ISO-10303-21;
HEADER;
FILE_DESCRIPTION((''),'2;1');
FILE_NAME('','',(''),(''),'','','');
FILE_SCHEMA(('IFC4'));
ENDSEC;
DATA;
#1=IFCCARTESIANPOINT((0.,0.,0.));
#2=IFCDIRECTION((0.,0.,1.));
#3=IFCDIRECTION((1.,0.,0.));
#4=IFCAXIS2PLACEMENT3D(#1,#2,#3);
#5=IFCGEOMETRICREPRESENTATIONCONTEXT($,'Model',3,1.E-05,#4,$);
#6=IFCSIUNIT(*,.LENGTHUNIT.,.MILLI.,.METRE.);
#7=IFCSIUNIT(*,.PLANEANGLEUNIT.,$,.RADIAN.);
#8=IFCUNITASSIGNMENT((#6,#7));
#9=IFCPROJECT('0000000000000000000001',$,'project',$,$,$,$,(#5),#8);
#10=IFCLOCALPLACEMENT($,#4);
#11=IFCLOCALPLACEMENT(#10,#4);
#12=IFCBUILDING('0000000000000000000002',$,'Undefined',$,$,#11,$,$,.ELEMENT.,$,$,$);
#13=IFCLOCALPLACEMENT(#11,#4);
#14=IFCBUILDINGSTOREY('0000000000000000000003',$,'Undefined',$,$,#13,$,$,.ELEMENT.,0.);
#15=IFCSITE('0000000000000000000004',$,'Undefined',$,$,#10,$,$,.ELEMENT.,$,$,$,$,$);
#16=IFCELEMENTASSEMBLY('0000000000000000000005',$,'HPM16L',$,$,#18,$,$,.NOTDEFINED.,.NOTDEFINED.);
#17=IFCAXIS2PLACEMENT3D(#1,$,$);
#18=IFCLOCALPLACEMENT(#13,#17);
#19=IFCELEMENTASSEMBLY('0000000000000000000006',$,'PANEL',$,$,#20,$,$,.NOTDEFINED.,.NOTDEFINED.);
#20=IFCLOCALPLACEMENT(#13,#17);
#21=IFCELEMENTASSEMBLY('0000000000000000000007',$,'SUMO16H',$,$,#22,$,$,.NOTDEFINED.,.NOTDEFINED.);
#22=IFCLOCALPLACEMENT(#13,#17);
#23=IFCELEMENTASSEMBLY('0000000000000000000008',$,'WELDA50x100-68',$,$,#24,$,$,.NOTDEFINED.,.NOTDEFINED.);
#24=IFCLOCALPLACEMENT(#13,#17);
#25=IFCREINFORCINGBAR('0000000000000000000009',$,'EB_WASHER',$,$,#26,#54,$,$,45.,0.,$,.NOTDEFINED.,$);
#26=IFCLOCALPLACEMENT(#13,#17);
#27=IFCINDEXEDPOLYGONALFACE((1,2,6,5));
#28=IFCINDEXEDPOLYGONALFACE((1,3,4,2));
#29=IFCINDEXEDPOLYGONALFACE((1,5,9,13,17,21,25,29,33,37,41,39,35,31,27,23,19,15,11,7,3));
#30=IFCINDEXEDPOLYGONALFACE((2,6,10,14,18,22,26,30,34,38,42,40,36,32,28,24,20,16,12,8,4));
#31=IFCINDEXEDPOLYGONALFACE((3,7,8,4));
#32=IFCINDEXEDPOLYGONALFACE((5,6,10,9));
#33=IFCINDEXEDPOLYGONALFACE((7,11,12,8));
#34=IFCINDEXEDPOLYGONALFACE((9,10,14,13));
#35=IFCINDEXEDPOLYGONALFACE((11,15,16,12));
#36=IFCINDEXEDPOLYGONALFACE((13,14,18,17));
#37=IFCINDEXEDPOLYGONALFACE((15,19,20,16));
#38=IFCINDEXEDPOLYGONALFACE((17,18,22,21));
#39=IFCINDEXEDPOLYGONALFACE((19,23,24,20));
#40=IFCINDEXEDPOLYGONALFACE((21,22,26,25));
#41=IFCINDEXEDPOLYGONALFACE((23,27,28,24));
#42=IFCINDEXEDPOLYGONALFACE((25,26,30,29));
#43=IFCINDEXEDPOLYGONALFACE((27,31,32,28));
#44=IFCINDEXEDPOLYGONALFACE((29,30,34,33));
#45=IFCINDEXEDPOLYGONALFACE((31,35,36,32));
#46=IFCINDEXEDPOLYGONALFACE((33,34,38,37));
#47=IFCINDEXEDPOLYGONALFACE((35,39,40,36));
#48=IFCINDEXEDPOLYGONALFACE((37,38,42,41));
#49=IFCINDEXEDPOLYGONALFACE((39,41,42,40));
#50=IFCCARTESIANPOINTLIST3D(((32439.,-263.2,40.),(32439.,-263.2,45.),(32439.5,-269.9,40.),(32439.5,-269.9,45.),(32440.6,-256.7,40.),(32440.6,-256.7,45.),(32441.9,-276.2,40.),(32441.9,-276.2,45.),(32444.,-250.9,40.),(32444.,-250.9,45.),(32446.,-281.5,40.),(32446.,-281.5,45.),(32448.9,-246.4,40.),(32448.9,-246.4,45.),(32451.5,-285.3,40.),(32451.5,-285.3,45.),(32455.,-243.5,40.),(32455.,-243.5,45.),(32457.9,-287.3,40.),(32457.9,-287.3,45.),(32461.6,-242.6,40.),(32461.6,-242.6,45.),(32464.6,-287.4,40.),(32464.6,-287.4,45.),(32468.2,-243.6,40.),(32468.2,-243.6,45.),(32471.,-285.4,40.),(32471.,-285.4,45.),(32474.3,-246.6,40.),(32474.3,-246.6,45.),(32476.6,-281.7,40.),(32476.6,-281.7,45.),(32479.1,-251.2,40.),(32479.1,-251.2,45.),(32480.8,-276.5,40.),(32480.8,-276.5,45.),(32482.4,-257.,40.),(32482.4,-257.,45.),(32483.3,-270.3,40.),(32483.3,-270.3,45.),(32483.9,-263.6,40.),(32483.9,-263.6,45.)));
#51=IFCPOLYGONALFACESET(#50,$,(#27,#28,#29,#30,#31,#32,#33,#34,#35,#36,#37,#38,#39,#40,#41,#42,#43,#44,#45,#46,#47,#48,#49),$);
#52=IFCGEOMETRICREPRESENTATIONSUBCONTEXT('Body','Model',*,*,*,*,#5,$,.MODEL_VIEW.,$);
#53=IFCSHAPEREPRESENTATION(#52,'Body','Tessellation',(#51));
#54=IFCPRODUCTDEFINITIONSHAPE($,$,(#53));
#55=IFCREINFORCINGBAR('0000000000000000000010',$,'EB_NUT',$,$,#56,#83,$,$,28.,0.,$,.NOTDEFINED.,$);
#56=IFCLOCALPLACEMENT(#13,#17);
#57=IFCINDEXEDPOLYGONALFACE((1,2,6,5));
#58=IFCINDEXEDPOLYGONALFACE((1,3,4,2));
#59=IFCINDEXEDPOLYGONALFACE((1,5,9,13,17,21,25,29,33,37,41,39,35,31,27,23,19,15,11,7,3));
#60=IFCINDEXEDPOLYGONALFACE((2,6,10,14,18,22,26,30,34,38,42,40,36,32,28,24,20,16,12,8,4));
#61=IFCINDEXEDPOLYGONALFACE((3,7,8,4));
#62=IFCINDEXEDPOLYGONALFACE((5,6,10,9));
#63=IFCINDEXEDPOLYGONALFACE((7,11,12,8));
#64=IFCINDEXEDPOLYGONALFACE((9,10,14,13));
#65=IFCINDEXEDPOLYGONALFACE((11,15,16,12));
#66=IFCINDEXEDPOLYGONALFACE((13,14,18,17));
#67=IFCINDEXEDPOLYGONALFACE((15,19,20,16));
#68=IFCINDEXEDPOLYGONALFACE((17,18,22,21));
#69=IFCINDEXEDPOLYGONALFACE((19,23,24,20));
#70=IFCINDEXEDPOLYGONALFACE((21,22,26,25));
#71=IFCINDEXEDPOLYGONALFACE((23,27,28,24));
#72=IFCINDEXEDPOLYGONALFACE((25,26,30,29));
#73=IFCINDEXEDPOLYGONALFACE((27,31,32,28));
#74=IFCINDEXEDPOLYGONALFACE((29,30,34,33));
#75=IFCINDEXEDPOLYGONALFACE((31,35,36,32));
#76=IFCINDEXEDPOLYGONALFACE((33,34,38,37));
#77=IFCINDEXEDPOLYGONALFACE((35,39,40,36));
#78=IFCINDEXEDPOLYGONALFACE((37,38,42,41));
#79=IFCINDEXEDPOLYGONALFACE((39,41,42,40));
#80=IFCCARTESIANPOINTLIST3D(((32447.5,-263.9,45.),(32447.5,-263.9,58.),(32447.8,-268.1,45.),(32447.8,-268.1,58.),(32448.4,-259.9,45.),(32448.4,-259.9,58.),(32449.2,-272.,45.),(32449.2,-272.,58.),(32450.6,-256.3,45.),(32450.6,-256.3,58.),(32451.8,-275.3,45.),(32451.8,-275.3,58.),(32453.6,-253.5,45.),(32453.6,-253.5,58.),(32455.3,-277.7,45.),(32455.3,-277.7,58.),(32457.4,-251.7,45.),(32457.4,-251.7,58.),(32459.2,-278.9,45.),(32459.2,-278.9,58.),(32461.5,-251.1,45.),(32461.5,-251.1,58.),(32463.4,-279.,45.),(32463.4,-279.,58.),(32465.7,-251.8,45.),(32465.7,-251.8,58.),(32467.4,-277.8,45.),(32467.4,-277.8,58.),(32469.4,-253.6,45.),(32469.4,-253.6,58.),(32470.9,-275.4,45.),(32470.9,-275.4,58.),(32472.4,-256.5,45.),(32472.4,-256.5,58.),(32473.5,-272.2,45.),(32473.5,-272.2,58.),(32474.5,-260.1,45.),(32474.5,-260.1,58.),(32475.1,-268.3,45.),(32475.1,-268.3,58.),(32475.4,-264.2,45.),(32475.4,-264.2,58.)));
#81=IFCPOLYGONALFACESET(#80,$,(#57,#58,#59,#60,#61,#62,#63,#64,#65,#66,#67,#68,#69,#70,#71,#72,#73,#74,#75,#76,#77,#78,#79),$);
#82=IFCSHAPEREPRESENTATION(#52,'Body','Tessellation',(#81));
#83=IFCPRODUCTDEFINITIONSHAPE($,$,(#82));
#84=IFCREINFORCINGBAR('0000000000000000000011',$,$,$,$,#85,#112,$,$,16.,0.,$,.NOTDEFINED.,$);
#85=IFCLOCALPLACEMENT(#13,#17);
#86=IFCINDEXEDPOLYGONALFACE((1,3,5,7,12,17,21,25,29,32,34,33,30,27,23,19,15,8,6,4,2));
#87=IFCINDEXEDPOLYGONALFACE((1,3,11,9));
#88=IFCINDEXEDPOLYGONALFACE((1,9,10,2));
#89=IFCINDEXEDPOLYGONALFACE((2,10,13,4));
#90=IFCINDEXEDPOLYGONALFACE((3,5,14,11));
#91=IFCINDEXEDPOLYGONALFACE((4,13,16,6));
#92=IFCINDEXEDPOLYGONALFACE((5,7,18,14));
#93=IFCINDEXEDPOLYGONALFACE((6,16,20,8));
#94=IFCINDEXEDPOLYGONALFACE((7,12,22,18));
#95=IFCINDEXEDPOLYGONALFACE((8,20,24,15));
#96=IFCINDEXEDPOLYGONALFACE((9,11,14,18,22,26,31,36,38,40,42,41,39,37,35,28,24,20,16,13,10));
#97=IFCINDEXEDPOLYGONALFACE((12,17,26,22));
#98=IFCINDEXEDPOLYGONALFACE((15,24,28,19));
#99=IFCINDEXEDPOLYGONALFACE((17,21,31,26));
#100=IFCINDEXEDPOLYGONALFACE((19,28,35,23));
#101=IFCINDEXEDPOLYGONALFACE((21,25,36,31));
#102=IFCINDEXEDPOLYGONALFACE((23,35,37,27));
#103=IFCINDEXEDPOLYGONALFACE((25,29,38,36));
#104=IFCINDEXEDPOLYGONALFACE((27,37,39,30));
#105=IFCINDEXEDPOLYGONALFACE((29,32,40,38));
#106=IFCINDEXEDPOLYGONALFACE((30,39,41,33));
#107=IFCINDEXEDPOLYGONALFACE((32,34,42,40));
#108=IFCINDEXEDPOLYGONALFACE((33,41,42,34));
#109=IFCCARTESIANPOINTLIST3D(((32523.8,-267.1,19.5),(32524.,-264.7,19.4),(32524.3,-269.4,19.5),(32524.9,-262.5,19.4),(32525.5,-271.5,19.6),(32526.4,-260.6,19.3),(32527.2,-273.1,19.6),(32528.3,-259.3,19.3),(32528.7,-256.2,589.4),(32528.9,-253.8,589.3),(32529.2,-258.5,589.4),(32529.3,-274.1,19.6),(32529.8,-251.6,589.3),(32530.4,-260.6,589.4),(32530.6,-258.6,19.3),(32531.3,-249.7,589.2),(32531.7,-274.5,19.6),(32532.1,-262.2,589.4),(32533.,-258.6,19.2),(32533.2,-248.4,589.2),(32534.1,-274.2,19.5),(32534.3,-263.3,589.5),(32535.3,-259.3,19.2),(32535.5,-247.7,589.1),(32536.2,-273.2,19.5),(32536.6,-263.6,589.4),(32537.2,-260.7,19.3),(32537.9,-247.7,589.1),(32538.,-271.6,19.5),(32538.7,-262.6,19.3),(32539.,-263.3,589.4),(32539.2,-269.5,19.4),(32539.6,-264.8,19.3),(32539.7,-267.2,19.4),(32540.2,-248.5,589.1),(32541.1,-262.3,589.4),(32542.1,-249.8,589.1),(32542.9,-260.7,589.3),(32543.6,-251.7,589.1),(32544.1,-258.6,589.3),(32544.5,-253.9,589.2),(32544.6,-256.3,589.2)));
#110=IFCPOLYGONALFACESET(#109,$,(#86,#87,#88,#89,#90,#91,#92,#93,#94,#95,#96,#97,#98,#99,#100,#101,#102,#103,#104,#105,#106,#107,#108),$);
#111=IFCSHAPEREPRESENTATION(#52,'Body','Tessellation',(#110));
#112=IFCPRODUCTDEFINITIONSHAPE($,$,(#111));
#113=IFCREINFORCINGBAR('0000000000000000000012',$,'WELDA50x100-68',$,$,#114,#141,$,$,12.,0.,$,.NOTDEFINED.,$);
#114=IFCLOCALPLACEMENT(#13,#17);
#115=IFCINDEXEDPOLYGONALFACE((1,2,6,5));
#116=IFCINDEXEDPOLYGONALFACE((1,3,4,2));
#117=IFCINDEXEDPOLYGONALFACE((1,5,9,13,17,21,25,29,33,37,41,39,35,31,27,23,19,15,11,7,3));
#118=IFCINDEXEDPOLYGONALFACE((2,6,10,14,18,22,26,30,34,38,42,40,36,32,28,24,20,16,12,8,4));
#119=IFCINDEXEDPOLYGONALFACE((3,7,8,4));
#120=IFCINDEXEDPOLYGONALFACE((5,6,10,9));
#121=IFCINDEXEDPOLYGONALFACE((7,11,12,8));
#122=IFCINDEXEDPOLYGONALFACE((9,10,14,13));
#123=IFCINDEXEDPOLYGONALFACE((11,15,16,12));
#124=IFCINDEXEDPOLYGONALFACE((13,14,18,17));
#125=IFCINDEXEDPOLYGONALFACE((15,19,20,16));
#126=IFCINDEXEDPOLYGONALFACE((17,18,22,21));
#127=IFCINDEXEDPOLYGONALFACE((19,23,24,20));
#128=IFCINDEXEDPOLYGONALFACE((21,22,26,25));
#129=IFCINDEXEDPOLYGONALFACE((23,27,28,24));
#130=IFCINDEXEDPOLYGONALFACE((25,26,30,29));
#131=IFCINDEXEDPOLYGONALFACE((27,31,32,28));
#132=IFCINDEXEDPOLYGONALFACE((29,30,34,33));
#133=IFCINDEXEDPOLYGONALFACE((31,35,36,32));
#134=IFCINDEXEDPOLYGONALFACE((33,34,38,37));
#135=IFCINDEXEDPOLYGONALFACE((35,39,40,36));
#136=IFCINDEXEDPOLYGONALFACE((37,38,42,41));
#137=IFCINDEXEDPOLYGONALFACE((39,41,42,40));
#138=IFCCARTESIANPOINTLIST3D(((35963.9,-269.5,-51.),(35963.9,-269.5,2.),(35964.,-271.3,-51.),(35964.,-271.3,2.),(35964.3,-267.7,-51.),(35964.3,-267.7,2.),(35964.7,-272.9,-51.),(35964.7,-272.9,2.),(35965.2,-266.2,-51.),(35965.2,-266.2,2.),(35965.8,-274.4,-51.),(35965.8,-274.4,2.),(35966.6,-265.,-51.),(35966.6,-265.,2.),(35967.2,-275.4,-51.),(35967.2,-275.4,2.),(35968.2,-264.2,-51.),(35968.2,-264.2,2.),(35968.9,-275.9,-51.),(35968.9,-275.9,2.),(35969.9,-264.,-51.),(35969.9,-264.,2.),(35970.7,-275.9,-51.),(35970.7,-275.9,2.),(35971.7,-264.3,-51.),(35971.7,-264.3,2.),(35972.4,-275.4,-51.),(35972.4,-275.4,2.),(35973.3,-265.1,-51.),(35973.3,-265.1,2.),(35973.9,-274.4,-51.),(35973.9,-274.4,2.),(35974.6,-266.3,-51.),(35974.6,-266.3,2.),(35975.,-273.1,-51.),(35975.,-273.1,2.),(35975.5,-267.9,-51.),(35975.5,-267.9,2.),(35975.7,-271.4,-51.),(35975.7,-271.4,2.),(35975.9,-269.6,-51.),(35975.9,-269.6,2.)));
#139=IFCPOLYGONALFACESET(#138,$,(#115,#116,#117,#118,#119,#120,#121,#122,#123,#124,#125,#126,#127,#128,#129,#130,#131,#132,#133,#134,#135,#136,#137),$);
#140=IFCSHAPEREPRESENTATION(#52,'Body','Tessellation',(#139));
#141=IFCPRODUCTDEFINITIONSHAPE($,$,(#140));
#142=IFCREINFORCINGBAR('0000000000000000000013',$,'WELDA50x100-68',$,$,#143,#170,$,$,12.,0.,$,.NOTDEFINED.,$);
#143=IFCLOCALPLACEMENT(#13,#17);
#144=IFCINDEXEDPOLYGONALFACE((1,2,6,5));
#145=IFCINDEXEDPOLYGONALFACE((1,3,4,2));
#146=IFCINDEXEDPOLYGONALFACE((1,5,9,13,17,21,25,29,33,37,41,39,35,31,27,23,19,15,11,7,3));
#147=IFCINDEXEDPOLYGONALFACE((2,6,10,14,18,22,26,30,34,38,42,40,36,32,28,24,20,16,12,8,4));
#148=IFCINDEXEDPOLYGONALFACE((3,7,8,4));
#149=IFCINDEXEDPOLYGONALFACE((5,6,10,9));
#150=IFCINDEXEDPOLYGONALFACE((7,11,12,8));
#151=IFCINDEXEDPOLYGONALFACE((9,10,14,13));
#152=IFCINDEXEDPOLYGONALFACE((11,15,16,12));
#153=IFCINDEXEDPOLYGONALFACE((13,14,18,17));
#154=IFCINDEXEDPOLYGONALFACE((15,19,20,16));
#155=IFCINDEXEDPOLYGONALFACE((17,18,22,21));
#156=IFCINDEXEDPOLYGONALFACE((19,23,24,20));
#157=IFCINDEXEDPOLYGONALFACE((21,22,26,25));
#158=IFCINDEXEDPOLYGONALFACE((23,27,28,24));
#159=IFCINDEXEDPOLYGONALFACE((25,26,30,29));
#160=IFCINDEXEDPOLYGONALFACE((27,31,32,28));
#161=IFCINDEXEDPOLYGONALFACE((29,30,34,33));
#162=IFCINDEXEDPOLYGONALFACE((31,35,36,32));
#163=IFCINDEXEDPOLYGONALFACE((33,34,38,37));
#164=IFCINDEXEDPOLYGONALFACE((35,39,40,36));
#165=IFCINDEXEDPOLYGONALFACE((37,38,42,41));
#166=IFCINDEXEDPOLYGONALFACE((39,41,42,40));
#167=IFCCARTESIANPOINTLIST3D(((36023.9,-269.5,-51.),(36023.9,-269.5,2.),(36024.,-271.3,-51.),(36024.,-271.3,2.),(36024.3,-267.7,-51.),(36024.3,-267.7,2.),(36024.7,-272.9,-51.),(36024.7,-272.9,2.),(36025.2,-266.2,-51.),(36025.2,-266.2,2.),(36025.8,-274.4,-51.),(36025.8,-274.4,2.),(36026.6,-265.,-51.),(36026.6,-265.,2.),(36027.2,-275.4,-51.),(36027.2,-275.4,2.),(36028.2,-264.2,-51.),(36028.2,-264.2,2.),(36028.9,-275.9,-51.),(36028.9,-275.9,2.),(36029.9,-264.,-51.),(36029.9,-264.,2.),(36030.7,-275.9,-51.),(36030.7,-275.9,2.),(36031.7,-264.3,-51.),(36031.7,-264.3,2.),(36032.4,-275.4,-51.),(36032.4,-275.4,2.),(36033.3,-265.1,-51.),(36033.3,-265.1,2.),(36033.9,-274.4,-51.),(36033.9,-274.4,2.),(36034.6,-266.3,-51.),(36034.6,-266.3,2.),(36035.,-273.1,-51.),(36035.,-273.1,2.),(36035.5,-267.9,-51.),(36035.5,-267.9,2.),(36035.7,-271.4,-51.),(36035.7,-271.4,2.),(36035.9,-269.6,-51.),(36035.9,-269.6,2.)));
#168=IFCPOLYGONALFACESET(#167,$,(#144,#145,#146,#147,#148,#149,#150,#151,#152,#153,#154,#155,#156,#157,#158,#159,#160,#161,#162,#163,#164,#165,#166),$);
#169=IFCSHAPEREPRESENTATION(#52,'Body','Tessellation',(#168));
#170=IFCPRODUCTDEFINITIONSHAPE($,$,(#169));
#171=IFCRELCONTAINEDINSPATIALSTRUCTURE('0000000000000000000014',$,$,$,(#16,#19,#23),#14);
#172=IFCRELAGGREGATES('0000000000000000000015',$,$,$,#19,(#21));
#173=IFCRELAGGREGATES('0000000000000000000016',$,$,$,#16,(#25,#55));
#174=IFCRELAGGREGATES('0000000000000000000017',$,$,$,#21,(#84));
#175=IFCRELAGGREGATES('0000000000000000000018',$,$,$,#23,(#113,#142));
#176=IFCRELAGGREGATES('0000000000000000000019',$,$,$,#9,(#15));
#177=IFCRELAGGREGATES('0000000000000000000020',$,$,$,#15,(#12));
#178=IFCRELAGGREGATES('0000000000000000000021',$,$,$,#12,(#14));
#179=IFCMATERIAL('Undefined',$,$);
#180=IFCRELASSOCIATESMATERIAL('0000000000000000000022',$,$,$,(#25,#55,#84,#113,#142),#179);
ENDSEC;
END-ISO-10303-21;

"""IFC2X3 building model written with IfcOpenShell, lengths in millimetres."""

from ifc_helpers import new_model, entity, si_unit, frame, origin_with_axes, place, context, subcontext, project, spatial, source, transform, mapped, material, element, aggregate, save


model = new_model("IFC2X3")

# Units and contexts
model_context = context("Model", 3, precision=1e-05, world=origin_with_axes())
body_context = subcontext(model_context, "Body", "Model", "MODEL_VIEW")
ifc_project = project(units=[si_unit("LENGTHUNIT", "METRE", prefix="MILLI"), si_unit("PLANEANGLEUNIT", "RADIAN")], contexts=[model_context])

# Site, building, storey
site_placement = place(None, origin_with_axes())
site = spatial("IfcSite", under=ifc_project, at=site_placement, Name="Undefined", CompositionType="ELEMENT")
building_placement = place(site_placement, origin_with_axes())
building = spatial("IfcBuilding", under=site, at=building_placement, Name="Undefined", CompositionType="ELEMENT")
storey_placement = place(building_placement, origin_with_axes())
storey = spatial("IfcBuildingStorey", under=building, at=storey_placement, Name="Undefined", CompositionType="ELEMENT", Elevation=0.0)

# Element assembly
assembly_1_placement = place(storey_placement, origin_with_axes())
assembly_1 = element("IfcElementAssembly", 1, at=assembly_1_placement, inside=storey, Name="HPM16L", AssemblyPlace="NOTDEFINED", PredefinedType="NOTDEFINED")

# Element assemblies
assembly_2_placement = place(storey_placement, origin_with_axes())
assembly_2 = element("IfcElementAssembly", 2, at=assembly_2_placement, inside=storey, Name="PANEL", AssemblyPlace="NOTDEFINED", PredefinedType="NOTDEFINED")
assembly_3_placement = place(assembly_2_placement, origin_with_axes())
assembly_3 = element("IfcElementAssembly", 3, at=assembly_3_placement, Name="SUMO16H", AssemblyPlace="NOTDEFINED", PredefinedType="NOTDEFINED")
aggregate(assembly_2, [assembly_3])

# Element assembly
assembly_4_placement = place(storey_placement, origin_with_axes())
assembly_4 = element("IfcElementAssembly", 4, at=assembly_4_placement, inside=storey, Name="WELDA50x100-68", AssemblyPlace="NOTDEFINED", PredefinedType="NOTDEFINED")

# Reinforcing bars
ifc_material_1 = material(Name="Undefined")
shared_shape_1 = source(origin_with_axes(), body_context, "Body", "AdvancedSweptSolid", [
    entity("IfcSweptDiskSolid", entity("IfcTrimmedCurve", entity("IfcLine", entity("IfcCartesianPoint", [0.0, 0.0, 0.0]), entity("IfcVector", entity("IfcDirection", [1.0, 0.0, 0.0]), 1.0)), [entity("IfcParameterValue", 0.0)], [entity("IfcParameterValue", 5.0)], True, "PARAMETER"), 22.5, None, 0.0, 5.0),
])
reinforcing_bar_1_placement = place(assembly_1_placement, frame((32461.4, -265.1, 45.0), z_axis=(0.008166, 0.999967, 0.0), x_axis=(0.0, 0.0, -1.0)))
reinforcing_bar_1 = element("IfcReinforcingBar", 5, at=reinforcing_bar_1_placement, material=ifc_material_1, Name="EB_WASHER", BarRole="NOTDEFINED", CrossSectionArea=0.0, NominalDiameter=45.0, context=body_context, shape_type="MappedRepresentation", body=[
    mapped(shared_shape_1, transform((0.0, 0.0, 0.0))),
])
shared_shape_2 = source(origin_with_axes(), body_context, "Body", "AdvancedSweptSolid", [
    entity("IfcSweptDiskSolid", entity("IfcTrimmedCurve", entity("IfcLine", entity("IfcCartesianPoint", [0.0, 0.0, 0.0]), entity("IfcVector", entity("IfcDirection", [1.0, 0.0, 0.0]), 1.0)), [entity("IfcParameterValue", 0.0)], [entity("IfcParameterValue", 13.0)], True, "PARAMETER"), 14.0, None, 0.0, 13.0),
])
reinforcing_bar_2_placement = place(assembly_1_placement, frame((32461.4, -265.1, 58.0), z_axis=(0.008166, 0.999967, 0.0), x_axis=(0.0, 0.0, -1.0)))
reinforcing_bar_2 = element("IfcReinforcingBar", 6, at=reinforcing_bar_2_placement, material=ifc_material_1, Name="EB_NUT", BarRole="NOTDEFINED", CrossSectionArea=0.0, NominalDiameter=28.0, context=body_context, shape_type="MappedRepresentation", body=[
    mapped(shared_shape_2, transform((0.0, 0.0, 0.0))),
])
aggregate(assembly_1, [reinforcing_bar_1, reinforcing_bar_2])
shared_shape_3 = source(origin_with_axes(), body_context, "Body", "AdvancedSweptSolid", [
    entity("IfcSweptDiskSolid", entity("IfcTrimmedCurve", entity("IfcLine", entity("IfcCartesianPoint", [0.0, 0.0, 0.0]), entity("IfcVector", entity("IfcDirection", [1.0, 0.0, 0.0]), 1.0)), [entity("IfcParameterValue", 0.0)], [entity("IfcParameterValue", 570.0)], True, "PARAMETER"), 8.0, None, 0.0, 570.0),
])
reinforcing_bar_3_placement = place(assembly_3_placement, frame((32531.8, -266.5, 19.4), z_axis=(-0.006955, -0.999792, 0.019153), x_axis=(0.008618, 0.019092, 0.999781)))
reinforcing_bar_3 = element("IfcReinforcingBar", 7, at=reinforcing_bar_3_placement, material=ifc_material_1, BarRole="NOTDEFINED", CrossSectionArea=0.0, NominalDiameter=16.0, context=body_context, shape_type="MappedRepresentation", body=[
    mapped(shared_shape_3, transform((0.0, 0.0, 0.0))),
])
aggregate(assembly_3, [reinforcing_bar_3])
shared_shape_4 = source(origin_with_axes(), body_context, "Body", "AdvancedSweptSolid", [
    entity("IfcSweptDiskSolid", entity("IfcTrimmedCurve", entity("IfcLine", entity("IfcCartesianPoint", [0.0, 0.0, 0.0]), entity("IfcVector", entity("IfcDirection", [1.0, 0.0, 0.0]), 1.0)), [entity("IfcParameterValue", 0.0)], [entity("IfcParameterValue", 53.0)], True, "PARAMETER"), 6.0, None, 0.0, 53.0),
])
reinforcing_bar_4_placement = place(assembly_4_placement, frame((35969.9, -270.0, 2.0), z_axis=(0.011111, 0.999938, 0.0), x_axis=(0.0, 0.0, -1.0)))
reinforcing_bar_4 = element("IfcReinforcingBar", 8, at=reinforcing_bar_4_placement, material=ifc_material_1, Name="WELDA50x100-68", BarRole="NOTDEFINED", CrossSectionArea=0.0, NominalDiameter=12.0, context=body_context, shape_type="MappedRepresentation", body=[
    mapped(shared_shape_4, transform((0.0, 0.0, 0.0))),
])
shared_shape_5 = source(origin_with_axes(), body_context, "Body", "AdvancedSweptSolid", [
    entity("IfcSweptDiskSolid", entity("IfcTrimmedCurve", entity("IfcLine", entity("IfcCartesianPoint", [0.0, 0.0, 0.0]), entity("IfcVector", entity("IfcDirection", [1.0, 0.0, 0.0]), 1.0)), [entity("IfcParameterValue", 0.0)], [entity("IfcParameterValue", 53.0)], True, "PARAMETER"), 6.0, None, 0.0, 53.0),
])
reinforcing_bar_5_placement = place(assembly_4_placement, frame((36029.9, -270.0, 2.0), z_axis=(0.011111, 0.999938, 0.0), x_axis=(0.0, 0.0, -1.0)))
reinforcing_bar_5 = element("IfcReinforcingBar", 9, at=reinforcing_bar_5_placement, material=ifc_material_1, Name="WELDA50x100-68", BarRole="NOTDEFINED", CrossSectionArea=0.0, NominalDiameter=12.0, context=body_context, shape_type="MappedRepresentation", body=[
    mapped(shared_shape_5, transform((0.0, 0.0, 0.0))),
])
aggregate(assembly_4, [reinforcing_bar_4, reinforcing_bar_5])

save(model, "model.ifc")
